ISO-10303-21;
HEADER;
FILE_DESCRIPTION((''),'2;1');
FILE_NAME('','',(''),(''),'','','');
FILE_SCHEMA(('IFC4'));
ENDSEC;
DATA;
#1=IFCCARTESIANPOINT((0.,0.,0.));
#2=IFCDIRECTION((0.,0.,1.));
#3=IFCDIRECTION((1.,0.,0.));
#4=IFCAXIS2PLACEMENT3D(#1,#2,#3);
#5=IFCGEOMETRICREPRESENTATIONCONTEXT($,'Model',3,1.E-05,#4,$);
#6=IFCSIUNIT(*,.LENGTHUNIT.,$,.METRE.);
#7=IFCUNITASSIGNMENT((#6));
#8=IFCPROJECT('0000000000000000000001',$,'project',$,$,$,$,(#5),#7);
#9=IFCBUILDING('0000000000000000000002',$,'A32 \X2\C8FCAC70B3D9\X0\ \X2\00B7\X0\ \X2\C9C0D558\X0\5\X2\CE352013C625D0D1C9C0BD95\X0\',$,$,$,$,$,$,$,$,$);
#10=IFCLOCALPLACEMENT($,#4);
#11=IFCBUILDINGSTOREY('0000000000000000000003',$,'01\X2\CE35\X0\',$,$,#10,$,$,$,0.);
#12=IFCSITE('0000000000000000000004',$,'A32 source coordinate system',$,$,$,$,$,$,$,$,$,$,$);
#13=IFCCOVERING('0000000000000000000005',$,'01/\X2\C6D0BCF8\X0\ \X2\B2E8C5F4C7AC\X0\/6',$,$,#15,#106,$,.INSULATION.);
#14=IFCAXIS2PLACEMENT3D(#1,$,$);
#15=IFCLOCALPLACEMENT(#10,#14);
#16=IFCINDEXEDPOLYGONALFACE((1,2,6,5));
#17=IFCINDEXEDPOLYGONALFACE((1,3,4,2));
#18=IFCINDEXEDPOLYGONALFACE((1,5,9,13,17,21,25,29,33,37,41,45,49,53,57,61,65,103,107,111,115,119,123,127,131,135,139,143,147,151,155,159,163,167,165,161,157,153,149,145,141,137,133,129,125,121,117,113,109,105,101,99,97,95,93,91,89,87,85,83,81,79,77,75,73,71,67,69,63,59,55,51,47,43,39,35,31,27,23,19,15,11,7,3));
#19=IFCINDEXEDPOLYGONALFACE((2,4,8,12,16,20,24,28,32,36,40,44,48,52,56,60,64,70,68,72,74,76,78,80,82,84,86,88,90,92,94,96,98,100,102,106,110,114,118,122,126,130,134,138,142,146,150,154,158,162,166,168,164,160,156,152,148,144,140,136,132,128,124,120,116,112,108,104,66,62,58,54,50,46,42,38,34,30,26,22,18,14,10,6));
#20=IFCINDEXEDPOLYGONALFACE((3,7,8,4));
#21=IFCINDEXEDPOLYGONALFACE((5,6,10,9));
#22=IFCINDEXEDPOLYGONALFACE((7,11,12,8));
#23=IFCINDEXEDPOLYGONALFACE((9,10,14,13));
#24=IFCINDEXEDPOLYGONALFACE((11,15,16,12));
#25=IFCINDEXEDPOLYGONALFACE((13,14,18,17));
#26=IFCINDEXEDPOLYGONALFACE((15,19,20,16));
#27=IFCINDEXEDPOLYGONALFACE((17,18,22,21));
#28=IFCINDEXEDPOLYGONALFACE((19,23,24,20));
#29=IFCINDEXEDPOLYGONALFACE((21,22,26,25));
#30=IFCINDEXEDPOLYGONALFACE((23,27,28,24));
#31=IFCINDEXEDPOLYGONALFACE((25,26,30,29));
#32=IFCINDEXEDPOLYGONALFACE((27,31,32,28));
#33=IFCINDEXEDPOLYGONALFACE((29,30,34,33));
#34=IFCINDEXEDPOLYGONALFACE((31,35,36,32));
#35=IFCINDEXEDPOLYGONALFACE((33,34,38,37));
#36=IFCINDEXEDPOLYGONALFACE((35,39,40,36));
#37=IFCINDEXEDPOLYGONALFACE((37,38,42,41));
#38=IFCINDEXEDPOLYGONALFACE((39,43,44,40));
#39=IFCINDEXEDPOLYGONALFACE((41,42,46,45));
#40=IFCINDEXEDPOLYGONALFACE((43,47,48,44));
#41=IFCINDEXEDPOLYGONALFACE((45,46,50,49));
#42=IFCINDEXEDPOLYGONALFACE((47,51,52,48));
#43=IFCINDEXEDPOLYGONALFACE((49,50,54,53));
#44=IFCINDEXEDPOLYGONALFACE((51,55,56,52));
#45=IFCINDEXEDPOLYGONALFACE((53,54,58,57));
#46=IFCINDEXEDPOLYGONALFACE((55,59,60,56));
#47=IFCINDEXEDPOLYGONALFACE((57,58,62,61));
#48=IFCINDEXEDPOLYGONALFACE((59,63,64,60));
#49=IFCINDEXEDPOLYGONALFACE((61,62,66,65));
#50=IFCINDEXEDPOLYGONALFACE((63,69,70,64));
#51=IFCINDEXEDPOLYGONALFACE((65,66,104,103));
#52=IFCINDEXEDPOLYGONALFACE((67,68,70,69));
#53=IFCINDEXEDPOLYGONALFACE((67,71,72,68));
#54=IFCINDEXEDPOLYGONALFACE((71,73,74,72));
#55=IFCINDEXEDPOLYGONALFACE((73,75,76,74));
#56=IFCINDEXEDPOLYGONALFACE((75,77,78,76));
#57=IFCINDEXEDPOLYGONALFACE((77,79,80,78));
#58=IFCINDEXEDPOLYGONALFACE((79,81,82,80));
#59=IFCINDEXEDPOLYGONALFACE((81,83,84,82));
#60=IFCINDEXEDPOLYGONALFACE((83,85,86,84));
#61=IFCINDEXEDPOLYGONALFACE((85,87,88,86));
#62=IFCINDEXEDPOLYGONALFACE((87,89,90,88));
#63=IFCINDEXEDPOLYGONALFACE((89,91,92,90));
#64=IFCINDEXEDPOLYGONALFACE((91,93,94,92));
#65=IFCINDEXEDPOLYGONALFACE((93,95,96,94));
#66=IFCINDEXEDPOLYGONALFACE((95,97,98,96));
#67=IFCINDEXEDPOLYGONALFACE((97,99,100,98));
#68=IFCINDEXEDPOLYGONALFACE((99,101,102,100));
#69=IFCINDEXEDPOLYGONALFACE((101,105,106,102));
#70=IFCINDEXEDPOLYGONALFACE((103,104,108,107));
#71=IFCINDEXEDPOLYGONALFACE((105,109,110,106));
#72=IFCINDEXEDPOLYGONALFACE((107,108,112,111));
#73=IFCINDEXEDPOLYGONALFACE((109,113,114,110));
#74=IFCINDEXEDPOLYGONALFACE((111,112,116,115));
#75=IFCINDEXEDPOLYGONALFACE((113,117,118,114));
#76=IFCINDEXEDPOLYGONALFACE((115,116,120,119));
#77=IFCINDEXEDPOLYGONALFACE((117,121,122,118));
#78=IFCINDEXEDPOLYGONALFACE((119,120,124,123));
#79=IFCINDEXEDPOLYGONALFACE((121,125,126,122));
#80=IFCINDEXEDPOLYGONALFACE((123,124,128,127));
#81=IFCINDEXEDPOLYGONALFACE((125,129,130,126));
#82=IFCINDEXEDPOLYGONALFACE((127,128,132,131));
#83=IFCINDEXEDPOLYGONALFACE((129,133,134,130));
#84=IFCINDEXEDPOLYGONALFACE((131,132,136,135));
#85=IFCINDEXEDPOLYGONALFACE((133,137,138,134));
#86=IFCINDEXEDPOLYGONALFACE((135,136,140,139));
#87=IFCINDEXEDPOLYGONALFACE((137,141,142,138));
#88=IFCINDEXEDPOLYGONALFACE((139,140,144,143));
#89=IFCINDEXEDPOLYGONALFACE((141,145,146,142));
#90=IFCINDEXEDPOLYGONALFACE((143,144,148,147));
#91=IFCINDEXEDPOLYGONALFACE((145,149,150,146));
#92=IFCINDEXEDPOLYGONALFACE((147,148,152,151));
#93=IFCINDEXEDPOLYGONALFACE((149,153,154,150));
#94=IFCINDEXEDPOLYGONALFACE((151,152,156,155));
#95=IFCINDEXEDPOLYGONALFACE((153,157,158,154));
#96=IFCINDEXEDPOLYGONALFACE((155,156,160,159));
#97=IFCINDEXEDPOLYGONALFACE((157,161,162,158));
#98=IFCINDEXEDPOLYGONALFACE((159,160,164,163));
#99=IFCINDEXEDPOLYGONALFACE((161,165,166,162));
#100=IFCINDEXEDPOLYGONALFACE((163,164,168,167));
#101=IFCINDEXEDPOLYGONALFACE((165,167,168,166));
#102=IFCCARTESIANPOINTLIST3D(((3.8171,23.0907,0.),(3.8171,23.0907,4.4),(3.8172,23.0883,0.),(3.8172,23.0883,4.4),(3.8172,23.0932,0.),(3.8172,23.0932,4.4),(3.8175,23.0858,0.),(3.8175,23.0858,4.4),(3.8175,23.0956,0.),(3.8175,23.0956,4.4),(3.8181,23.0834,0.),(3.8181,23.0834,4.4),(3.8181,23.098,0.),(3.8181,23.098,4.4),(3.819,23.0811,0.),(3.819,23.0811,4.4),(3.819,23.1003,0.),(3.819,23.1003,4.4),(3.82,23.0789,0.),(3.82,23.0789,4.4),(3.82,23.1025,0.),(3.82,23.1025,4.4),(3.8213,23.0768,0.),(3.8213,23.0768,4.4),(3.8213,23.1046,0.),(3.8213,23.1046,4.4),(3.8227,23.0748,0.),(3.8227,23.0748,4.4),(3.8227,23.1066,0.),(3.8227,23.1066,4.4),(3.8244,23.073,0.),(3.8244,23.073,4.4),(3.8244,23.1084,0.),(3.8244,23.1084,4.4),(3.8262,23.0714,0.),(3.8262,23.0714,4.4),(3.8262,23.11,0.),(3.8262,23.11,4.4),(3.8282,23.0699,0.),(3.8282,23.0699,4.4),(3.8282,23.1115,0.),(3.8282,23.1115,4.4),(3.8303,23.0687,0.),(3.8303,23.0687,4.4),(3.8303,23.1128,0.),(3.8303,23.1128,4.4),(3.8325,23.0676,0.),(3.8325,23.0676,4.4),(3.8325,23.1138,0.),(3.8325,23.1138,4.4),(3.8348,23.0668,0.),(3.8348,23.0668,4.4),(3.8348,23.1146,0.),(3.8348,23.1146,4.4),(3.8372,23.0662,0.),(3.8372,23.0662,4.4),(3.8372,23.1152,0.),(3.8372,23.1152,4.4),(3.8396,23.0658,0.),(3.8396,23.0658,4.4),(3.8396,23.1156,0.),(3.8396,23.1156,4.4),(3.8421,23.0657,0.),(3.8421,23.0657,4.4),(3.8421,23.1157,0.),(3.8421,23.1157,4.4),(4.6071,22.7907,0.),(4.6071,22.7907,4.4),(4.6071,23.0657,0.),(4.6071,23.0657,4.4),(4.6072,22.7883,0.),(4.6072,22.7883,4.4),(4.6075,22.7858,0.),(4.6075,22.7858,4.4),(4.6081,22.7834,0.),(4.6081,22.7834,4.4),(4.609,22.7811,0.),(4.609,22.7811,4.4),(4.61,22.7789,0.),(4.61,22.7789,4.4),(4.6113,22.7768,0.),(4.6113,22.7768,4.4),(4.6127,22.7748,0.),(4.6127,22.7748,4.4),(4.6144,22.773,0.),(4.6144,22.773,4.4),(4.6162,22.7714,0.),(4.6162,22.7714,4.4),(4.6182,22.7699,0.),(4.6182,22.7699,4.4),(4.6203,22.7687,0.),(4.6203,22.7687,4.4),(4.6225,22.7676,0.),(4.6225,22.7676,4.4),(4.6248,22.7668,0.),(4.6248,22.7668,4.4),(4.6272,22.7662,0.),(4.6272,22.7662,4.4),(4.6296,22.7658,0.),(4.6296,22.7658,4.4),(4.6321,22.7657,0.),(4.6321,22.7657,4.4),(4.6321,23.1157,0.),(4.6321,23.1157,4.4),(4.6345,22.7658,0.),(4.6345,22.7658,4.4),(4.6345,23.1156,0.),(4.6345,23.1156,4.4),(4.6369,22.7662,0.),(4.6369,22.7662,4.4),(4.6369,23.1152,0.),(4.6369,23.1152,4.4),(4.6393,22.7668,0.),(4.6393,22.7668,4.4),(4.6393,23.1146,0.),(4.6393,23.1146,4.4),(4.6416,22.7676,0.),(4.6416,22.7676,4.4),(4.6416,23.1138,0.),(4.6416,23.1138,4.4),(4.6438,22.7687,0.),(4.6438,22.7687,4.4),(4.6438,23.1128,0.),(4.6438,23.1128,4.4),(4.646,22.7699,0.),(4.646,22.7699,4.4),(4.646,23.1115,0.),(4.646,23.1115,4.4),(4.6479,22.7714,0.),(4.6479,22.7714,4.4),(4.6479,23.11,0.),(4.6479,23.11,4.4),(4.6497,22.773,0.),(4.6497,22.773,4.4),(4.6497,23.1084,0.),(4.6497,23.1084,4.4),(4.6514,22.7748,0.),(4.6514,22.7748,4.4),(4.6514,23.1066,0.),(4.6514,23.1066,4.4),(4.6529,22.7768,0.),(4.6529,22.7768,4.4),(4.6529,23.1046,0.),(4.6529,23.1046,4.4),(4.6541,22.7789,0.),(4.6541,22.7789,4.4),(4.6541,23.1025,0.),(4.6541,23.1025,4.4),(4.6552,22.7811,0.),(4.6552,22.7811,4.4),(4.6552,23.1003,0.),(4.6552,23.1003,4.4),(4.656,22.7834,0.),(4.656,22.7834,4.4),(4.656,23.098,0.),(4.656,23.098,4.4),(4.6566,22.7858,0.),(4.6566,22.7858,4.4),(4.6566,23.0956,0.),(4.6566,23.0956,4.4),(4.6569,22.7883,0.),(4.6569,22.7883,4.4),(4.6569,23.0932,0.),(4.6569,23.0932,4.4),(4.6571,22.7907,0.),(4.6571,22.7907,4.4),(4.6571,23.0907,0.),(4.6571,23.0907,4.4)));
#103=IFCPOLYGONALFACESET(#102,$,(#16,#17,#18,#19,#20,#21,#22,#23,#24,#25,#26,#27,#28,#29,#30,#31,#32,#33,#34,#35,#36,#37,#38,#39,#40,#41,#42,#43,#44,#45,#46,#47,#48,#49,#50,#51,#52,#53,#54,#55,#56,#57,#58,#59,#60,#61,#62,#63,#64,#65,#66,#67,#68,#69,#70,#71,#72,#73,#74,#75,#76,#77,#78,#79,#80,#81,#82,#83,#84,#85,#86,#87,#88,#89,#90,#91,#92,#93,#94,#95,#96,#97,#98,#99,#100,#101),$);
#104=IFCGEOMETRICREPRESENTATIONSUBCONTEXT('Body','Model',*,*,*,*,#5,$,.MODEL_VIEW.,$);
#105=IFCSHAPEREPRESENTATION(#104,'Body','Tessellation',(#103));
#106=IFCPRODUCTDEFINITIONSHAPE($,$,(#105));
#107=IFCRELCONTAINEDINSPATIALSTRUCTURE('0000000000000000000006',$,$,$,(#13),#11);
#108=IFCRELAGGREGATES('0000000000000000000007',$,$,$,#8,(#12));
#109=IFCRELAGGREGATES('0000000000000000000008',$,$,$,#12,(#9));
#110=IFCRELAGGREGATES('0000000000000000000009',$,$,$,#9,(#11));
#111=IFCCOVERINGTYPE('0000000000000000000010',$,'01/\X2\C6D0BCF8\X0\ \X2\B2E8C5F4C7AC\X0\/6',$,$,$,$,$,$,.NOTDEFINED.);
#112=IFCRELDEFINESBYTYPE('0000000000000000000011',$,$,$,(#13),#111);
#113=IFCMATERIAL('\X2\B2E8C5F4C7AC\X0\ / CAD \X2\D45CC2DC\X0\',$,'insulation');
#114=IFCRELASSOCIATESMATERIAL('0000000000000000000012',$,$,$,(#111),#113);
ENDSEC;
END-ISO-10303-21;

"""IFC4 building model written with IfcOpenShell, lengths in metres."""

from ifc_helpers import new_model, si_unit, origin, origin_with_axes, place, context, subcontext, project, spatial, polyline, outline, extrude, source, transform, mapped, material, type_object, type_shapes, element, save


model = new_model("IFC4")

# Units and contexts
model_context = context("Model", 3, precision=1e-05, world=origin_with_axes())
body_context = subcontext(model_context, "Body", "Model", "MODEL_VIEW")
ifc_project = project(units=[si_unit("LENGTHUNIT", "METRE")], contexts=[model_context])

# Site, building, storey
site = spatial("IfcSite", under=ifc_project, Name="A32 source coordinate system")
building = spatial("IfcBuilding", under=site, Name="A32 주거동 · 지하5층–옥탑지붕")
storey_placement = place(None, origin_with_axes())
storey = spatial("IfcBuildingStorey", under=building, at=storey_placement, Name="01층", Elevation=0.0)

# Covering
ifc_material = material(Name="단열재 / CAD 표시", Category="insulation")
covering_type_1 = type_object("IfcCoveringType", Name="01/원본 단열재/6", PredefinedType="NOTDEFINED", material=ifc_material)
shared_shape_1 = source(origin(), body_context, "Body", "SweptSolid", [
    extrude(outline(polyline([(3.8303, 23.0687), (3.8282, 23.0699), (3.8262, 23.0714), (3.8244, 23.073), (3.8227, 23.0748), (3.8213, 23.0768), (3.82, 23.0789), (3.819, 23.0811), (3.8181, 23.0834), (3.8175, 23.0858), (3.8172, 23.0883), (3.8171, 23.0907), (3.8172, 23.0932), (3.8175, 23.0956), (3.8181, 23.098), (3.819, 23.1003), (3.82, 23.1025), (3.8213, 23.1046), (3.8227, 23.1066), (3.8244, 23.1084), (3.8262, 23.11), (3.8282, 23.1115), (3.8303, 23.1128), (3.8325, 23.1138), (3.8348, 23.1146), (3.8372, 23.1152), (3.8396, 23.1156), (3.8421, 23.1157), (4.6321, 23.1157), (4.6345, 23.1156), (4.6369, 23.1152), (4.6393, 23.1146), (4.6416, 23.1138), (4.6438, 23.1128), (4.646, 23.1115), (4.6479, 23.11), (4.6497, 23.1084), (4.6514, 23.1066), (4.6529, 23.1046), (4.6541, 23.1025), (4.6552, 23.1003), (4.656, 23.098), (4.6566, 23.0956), (4.6569, 23.0932), (4.6571, 23.0907), (4.6571, 22.7907), (4.6569, 22.7883), (4.6566, 22.7858), (4.656, 22.7834), (4.6552, 22.7811), (4.6541, 22.7789), (4.6529, 22.7768), (4.6514, 22.7748), (4.6497, 22.773), (4.6479, 22.7714), (4.646, 22.7699), (4.6438, 22.7687), (4.6416, 22.7676), (4.6393, 22.7668), (4.6369, 22.7662), (4.6345, 22.7658), (4.6321, 22.7657), (4.6296, 22.7658), (4.6272, 22.7662), (4.6248, 22.7668), (4.6225, 22.7676), (4.6203, 22.7687), (4.6182, 22.7699), (4.6162, 22.7714), (4.6144, 22.773), (4.6127, 22.7748), (4.6113, 22.7768), (4.61, 22.7789), (4.609, 22.7811), (4.6081, 22.7834), (4.6075, 22.7858), (4.6072, 22.7883), (4.6071, 22.7907), (4.6071, 23.0657), (3.8421, 23.0657), (3.8396, 23.0658), (3.8372, 23.0662), (3.8348, 23.0668), (3.8325, 23.0676), (3.8303, 23.0687)])), origin(), (0.0, 0.0, 1.0), 4.4),
])
type_shapes(covering_type_1, [shared_shape_1])
covering_1_placement = place(storey_placement, origin_with_axes())
element("IfcCovering", 1, at=covering_1_placement, inside=storey, type_object=covering_type_1, Name="01/원본 단열재/6", PredefinedType="INSULATION", context=body_context, shape_type="MappedRepresentation", body=[
    mapped(shared_shape_1, transform((0.0, 0.0, 0.0), scale=1.0)),
])

save(model, "model.ifc")
